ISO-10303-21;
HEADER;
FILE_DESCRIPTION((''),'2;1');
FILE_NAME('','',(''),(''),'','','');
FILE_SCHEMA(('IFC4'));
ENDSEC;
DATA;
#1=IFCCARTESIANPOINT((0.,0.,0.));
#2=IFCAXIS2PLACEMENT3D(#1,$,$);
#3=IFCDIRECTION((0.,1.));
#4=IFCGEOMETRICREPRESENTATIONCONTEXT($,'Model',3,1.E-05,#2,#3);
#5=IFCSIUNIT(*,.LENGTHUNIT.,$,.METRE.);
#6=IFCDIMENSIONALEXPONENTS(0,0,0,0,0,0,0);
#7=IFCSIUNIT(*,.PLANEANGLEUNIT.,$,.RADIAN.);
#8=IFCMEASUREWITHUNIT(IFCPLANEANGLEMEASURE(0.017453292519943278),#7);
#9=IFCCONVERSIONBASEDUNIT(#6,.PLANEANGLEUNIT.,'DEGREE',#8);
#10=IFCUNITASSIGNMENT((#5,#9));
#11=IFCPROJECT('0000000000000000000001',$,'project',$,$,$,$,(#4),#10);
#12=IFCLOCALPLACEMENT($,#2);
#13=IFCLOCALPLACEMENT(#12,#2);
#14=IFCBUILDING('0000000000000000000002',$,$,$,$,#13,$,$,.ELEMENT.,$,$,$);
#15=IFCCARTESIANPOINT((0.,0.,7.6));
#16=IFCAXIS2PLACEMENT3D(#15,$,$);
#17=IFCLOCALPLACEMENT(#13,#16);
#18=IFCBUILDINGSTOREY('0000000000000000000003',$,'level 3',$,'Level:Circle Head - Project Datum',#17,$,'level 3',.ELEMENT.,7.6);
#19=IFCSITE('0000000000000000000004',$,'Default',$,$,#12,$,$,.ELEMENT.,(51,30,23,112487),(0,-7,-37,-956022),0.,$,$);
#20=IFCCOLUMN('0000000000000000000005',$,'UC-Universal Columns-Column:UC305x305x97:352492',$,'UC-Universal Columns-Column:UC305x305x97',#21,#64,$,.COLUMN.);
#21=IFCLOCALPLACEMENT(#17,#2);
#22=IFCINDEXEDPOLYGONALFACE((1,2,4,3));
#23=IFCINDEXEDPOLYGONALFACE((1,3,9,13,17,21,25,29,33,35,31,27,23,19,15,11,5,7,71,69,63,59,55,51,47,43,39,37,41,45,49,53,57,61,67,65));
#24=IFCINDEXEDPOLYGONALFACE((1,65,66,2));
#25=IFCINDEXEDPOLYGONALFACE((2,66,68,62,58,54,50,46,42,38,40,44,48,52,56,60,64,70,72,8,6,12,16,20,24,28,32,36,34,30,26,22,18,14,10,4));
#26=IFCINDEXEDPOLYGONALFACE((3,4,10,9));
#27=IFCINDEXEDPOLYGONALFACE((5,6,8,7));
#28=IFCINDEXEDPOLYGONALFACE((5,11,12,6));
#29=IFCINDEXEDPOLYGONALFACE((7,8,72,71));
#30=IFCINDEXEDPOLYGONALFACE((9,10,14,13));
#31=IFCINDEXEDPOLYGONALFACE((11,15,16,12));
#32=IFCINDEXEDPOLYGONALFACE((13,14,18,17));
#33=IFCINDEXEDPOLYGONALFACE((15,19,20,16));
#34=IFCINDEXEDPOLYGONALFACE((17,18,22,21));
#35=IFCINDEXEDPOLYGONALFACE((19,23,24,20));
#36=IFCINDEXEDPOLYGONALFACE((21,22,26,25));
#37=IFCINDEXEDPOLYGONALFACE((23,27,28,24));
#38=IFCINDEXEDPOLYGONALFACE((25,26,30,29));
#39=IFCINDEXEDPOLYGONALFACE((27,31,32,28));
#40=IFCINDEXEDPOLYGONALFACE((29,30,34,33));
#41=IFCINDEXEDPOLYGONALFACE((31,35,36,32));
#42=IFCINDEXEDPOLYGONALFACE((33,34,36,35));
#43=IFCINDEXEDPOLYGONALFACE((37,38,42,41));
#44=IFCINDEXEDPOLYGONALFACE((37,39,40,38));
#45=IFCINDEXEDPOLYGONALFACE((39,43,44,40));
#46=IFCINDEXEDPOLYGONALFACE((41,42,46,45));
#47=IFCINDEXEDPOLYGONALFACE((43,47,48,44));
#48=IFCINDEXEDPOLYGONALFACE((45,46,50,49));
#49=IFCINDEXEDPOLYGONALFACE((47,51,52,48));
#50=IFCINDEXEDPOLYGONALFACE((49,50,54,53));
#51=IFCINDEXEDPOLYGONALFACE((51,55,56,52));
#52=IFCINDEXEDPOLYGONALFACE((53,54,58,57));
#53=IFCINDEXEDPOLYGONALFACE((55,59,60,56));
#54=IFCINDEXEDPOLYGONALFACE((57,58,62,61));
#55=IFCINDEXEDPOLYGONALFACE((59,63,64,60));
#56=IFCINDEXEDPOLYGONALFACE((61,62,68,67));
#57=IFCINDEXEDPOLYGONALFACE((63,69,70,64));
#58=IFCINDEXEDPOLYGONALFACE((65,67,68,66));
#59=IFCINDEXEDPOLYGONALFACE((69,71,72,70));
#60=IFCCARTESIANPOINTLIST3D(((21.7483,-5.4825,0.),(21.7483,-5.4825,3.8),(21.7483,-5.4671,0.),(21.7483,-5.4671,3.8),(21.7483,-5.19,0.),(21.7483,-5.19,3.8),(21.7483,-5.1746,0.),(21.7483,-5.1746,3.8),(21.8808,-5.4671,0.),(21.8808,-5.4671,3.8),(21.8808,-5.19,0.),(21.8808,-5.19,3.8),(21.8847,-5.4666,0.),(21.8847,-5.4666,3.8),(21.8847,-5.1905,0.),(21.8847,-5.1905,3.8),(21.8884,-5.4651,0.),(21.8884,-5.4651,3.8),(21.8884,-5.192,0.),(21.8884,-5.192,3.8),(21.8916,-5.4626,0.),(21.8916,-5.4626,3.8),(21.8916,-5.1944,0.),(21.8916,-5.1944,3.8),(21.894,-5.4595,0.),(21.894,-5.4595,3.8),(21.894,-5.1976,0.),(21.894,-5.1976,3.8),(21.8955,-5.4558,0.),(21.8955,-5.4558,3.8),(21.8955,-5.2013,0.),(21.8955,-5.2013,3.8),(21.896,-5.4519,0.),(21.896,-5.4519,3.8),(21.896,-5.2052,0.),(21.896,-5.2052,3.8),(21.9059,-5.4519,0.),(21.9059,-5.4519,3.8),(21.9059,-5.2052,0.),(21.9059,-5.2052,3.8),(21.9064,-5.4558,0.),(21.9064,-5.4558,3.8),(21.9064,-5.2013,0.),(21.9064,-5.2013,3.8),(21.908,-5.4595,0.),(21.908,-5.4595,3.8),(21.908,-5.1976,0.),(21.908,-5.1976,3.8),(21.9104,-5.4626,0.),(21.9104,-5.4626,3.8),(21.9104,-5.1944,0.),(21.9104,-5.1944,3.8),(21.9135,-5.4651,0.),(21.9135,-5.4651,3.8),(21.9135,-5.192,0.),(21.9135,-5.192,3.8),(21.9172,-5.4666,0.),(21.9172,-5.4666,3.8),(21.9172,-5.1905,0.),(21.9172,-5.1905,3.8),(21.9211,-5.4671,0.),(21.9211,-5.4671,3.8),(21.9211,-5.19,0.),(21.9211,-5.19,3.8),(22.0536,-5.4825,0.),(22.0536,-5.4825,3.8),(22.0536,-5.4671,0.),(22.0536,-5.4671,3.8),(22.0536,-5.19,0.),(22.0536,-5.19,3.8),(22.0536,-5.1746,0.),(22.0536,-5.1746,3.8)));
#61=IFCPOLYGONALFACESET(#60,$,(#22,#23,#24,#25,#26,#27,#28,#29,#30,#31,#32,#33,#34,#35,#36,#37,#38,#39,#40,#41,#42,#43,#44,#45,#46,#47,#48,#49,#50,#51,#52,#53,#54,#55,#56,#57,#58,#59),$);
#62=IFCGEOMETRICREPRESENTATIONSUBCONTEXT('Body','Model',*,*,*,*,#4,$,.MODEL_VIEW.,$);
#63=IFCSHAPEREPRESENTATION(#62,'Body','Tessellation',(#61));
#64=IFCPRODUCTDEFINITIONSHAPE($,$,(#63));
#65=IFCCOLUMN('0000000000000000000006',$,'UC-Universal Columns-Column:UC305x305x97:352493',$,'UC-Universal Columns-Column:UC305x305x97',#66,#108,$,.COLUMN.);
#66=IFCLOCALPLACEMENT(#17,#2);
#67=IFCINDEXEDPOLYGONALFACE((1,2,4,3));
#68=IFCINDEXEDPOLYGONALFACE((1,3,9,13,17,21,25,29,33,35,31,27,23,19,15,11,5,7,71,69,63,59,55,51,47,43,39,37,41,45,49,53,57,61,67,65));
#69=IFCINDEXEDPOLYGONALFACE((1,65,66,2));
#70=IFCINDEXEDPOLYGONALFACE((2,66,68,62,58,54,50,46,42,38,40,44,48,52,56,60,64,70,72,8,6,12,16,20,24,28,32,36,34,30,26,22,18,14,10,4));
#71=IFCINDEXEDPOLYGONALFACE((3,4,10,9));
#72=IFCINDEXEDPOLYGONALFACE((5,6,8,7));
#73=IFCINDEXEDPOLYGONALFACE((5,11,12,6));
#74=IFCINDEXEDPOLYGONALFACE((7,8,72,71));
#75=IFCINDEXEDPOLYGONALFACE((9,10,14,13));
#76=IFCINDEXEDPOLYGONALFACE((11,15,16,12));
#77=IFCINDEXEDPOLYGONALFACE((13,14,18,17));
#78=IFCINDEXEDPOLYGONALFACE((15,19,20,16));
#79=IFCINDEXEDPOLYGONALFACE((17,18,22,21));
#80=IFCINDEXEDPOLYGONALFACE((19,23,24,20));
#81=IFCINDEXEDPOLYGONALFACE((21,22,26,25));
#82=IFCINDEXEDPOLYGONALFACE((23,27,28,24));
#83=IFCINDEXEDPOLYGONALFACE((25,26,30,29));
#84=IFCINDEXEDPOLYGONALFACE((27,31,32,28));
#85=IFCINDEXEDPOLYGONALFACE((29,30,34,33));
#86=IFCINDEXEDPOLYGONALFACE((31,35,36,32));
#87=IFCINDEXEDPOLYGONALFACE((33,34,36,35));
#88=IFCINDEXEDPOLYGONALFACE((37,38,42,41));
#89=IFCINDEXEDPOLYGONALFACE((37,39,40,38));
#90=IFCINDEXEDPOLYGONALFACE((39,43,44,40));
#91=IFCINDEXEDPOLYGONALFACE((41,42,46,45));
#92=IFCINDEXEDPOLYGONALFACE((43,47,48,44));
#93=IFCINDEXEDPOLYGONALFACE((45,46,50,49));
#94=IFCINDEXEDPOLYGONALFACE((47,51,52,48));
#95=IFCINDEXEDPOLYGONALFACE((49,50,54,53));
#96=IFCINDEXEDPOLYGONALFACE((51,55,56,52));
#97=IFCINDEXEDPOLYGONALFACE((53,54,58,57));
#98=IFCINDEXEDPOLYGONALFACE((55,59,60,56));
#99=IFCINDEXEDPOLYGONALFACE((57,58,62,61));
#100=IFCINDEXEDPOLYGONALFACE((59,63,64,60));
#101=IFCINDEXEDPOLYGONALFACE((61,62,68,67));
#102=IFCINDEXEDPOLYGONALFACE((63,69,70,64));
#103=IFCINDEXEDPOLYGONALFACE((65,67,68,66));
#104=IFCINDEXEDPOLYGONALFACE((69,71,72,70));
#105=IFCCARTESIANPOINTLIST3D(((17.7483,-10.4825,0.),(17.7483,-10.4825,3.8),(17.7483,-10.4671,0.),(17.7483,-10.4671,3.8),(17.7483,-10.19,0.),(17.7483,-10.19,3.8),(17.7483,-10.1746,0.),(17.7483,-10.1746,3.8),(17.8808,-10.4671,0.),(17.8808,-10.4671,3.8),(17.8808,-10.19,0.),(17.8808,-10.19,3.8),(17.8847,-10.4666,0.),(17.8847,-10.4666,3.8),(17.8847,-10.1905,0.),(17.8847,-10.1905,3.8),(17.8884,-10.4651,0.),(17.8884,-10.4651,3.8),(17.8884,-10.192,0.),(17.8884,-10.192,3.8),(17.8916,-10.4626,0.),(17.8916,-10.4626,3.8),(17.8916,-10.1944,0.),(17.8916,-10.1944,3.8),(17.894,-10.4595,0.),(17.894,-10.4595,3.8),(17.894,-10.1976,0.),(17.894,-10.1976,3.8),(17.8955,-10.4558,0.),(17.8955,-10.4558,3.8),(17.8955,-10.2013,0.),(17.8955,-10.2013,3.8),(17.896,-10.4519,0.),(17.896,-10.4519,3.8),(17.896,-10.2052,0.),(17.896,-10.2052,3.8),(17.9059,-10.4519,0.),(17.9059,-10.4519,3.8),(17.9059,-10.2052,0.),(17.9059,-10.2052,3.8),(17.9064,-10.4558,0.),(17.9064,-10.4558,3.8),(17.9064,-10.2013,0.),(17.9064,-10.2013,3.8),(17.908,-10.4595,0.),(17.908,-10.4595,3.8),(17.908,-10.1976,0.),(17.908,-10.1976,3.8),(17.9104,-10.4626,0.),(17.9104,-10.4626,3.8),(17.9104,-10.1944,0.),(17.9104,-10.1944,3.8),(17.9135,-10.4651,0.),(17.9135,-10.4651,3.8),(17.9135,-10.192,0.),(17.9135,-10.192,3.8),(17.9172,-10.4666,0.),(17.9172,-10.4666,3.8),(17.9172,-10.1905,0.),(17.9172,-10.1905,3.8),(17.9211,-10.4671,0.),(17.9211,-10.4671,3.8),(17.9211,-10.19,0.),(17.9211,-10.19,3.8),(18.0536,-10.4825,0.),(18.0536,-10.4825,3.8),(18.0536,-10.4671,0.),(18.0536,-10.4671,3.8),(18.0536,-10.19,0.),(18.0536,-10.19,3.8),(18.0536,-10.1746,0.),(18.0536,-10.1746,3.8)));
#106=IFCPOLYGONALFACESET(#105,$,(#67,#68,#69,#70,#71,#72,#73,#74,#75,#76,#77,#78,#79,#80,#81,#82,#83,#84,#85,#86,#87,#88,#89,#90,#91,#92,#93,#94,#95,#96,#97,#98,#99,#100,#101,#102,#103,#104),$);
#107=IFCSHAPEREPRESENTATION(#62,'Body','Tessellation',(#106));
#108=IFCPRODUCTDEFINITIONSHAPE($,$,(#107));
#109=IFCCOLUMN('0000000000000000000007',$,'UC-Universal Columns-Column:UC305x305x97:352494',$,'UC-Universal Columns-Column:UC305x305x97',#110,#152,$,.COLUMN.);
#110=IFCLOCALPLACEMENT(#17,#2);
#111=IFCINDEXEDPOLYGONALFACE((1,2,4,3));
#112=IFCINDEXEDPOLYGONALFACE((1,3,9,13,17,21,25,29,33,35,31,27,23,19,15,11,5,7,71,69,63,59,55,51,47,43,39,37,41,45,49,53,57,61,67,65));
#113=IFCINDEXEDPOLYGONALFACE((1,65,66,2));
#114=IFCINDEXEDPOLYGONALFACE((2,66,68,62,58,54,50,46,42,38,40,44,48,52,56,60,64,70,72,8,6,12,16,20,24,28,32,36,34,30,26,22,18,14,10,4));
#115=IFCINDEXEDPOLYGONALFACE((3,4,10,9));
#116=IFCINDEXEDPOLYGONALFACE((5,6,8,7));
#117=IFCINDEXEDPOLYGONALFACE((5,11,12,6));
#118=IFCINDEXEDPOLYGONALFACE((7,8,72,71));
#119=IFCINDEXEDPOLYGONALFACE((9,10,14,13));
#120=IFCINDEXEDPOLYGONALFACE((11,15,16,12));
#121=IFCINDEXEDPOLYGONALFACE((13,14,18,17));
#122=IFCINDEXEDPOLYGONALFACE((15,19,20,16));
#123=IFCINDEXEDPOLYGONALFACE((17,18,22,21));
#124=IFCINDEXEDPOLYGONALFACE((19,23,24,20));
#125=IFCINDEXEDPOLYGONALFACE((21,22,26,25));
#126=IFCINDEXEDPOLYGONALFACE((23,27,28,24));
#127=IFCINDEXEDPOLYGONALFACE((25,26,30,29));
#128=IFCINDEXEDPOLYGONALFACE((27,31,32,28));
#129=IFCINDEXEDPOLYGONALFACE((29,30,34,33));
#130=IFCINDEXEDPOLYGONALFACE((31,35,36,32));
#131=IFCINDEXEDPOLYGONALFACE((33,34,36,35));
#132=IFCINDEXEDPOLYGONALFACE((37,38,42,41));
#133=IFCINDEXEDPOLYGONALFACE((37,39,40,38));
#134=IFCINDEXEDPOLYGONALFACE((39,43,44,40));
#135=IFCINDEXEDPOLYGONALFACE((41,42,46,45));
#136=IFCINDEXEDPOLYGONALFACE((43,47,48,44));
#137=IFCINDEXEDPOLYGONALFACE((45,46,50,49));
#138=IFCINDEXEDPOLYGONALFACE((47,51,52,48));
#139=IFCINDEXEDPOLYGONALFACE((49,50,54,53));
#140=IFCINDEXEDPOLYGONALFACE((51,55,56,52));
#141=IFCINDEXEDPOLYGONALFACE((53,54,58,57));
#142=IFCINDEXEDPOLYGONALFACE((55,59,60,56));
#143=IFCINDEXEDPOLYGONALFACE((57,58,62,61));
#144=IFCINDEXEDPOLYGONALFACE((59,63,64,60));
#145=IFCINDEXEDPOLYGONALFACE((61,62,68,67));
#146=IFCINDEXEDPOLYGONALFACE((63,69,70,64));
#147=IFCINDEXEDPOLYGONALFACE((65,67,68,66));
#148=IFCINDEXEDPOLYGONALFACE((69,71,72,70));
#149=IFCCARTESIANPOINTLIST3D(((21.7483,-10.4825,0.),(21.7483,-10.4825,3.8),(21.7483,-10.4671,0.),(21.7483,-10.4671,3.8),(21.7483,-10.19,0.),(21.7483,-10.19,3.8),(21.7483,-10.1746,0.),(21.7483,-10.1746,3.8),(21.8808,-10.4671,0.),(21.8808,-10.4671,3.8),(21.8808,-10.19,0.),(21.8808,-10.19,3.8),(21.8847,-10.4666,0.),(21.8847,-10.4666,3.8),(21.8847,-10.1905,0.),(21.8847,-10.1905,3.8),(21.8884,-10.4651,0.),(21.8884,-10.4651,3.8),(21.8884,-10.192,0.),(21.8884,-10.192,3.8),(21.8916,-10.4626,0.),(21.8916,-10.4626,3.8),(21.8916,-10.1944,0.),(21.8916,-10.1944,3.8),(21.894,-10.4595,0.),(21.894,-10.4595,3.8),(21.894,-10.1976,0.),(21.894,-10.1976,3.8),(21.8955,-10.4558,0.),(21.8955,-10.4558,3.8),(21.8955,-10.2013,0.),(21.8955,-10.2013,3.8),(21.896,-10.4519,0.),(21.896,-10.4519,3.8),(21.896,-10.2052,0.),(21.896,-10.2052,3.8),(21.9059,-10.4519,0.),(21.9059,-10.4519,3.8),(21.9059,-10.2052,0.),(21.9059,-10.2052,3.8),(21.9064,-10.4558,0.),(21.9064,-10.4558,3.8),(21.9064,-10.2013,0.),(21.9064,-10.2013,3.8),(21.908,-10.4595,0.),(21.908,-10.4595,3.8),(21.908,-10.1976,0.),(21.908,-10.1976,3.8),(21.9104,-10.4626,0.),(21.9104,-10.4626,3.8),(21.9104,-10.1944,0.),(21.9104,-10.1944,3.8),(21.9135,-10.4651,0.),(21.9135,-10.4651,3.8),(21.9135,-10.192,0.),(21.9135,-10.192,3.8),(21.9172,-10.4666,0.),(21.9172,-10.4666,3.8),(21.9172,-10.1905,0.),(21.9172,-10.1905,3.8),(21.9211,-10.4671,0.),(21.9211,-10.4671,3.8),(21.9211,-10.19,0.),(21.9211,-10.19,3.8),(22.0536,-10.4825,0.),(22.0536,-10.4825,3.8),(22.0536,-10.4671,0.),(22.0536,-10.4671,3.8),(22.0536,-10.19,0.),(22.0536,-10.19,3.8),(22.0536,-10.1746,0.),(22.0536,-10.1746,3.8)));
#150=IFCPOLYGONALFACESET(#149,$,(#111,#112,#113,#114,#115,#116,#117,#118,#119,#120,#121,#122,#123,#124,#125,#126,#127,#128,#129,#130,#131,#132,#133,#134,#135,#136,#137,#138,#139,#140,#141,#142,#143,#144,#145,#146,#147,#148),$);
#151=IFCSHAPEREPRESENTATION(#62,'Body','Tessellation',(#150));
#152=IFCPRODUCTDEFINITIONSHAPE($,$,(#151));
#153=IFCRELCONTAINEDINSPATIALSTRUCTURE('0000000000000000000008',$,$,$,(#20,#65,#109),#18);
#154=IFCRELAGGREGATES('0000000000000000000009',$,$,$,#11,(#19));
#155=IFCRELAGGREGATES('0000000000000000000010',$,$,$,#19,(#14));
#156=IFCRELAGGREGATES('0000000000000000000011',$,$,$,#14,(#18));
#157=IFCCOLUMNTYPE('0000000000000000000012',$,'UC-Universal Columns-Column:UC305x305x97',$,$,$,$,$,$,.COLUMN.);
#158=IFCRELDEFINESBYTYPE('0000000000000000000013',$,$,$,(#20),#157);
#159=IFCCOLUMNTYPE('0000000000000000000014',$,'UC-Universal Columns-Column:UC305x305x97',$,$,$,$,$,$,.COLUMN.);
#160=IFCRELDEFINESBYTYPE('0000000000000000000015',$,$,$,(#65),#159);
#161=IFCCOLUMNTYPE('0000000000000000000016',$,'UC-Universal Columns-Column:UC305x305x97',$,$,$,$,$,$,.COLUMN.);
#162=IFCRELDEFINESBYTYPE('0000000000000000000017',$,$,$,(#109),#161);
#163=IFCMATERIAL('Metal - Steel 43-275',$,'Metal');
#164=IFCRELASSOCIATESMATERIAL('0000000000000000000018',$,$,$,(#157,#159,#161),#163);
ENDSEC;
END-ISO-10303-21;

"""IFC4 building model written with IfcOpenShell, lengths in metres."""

from ifc_helpers import new_model, entity, si_unit, converted_unit, direction, frame, frame_2d, origin, place, context, subcontext, project, spatial, i_section, extrude, source, transform, mapped, material, material_profile, profile_set, type_object, type_shapes, element, save


model = new_model("IFC4")

# Units and contexts
model_context = context("Model", 3, precision=1e-05, world=origin(), true_north=direction((0.0, 1.0)))
body_context = subcontext(model_context, "Body", "Model", "MODEL_VIEW")
ifc_project = project(units=[si_unit("LENGTHUNIT", "METRE"), converted_unit("PLANEANGLEUNIT", "DEGREE", entity("IfcPlaneAngleMeasure", 0.017453292519943278), si_unit("PLANEANGLEUNIT", "RADIAN"), dimensions=[0, 0, 0, 0, 0, 0, 0])], contexts=[model_context])

# Site, building, storey
site_placement = place(None, origin())
site = spatial("IfcSite", under=ifc_project, at=site_placement, Name="Default", CompositionType="ELEMENT", RefLatitude=(51, 30, 23, 112487), RefLongitude=(0, -7, -37, -956022), RefElevation=0.0)
building_placement = place(site_placement, origin())
building = spatial("IfcBuilding", under=site, at=building_placement, CompositionType="ELEMENT")
storey_placement = place(building_placement, frame((0.0, 0.0, 7.6)))
storey = spatial("IfcBuildingStorey", under=building, at=storey_placement, Name="level 3", ObjectType="Level:Circle Head - Project Datum", LongName="level 3", CompositionType="ELEMENT", Elevation=7.6)

# Columns
ifc_material_1 = material(Name="Metal - Steel 43-275", Category="Metal")
ifc_material_profile_1 = material_profile(ifc_material_1, i_section(OverallWidth=0.3053, OverallDepth=0.3079, WebThickness=0.0099, FlangeThickness=0.0154, FilletRadius=0.0152, at=frame_2d((0.0, 0.0), x_axis=(1.0, 0.0))), Name="UC305x305x97")
ifc_profile_set_1 = profile_set([ifc_material_profile_1], Name="UC305x305x97")
column_type_1 = type_object("IfcColumnType", Name="UC-Universal Columns-Column:UC305x305x97", PredefinedType="COLUMN", material=ifc_profile_set_1)
shared_shape_1 = source(origin(), body_context, "Body", "SweptSolid", [
    extrude(i_section(OverallWidth=0.3053, OverallDepth=0.3079, WebThickness=0.0099, FlangeThickness=0.0154, FilletRadius=0.0152, at=frame_2d((0.0, 0.0), x_axis=(1.0, 0.0))), frame((21.901, -5.3285, 7.6), z_axis=(0.0, 0.0, 1.0), x_axis=(-1.0, 0.0, 0.0)), (0.0, 0.0, 1.0), 3.8),
])
type_shapes(column_type_1, [shared_shape_1])
column_1_placement = place(storey_placement, frame((0.0, 0.0, -7.6)))
element("IfcColumn", 1, at=column_1_placement, inside=storey, type_object=column_type_1, Name="UC-Universal Columns-Column:UC305x305x97:352492", ObjectType="UC-Universal Columns-Column:UC305x305x97", PredefinedType="COLUMN", context=body_context, shape_type="MappedRepresentation", body=[
    mapped(shared_shape_1, transform((0.0, 0.0, 0.0), scale=1.0)),
])
column_type_2 = type_object("IfcColumnType", Name="UC-Universal Columns-Column:UC305x305x97", PredefinedType="COLUMN", material=ifc_profile_set_1)
shared_shape_2 = source(origin(), body_context, "Body", "SweptSolid", [
    extrude(i_section(OverallWidth=0.3053, OverallDepth=0.3079, WebThickness=0.0099, FlangeThickness=0.0154, FilletRadius=0.0152, at=frame_2d((0.0, 0.0), x_axis=(1.0, 0.0))), frame((17.901, -10.3285, 7.6), z_axis=(0.0, 0.0, 1.0), x_axis=(-1.0, 0.0, 0.0)), (0.0, 0.0, 1.0), 3.8),
])
type_shapes(column_type_2, [shared_shape_2])
column_2_placement = place(storey_placement, frame((0.0, 0.0, -7.6)))
element("IfcColumn", 2, at=column_2_placement, inside=storey, type_object=column_type_2, Name="UC-Universal Columns-Column:UC305x305x97:352493", ObjectType="UC-Universal Columns-Column:UC305x305x97", PredefinedType="COLUMN", context=body_context, shape_type="MappedRepresentation", body=[
    mapped(shared_shape_2, transform((0.0, 0.0, 0.0), scale=1.0)),
])
column_type_3 = type_object("IfcColumnType", Name="UC-Universal Columns-Column:UC305x305x97", PredefinedType="COLUMN", material=ifc_profile_set_1)
shared_shape_3 = source(origin(), body_context, "Body", "SweptSolid", [
    extrude(i_section(OverallWidth=0.3053, OverallDepth=0.3079, WebThickness=0.0099, FlangeThickness=0.0154, FilletRadius=0.0152, at=frame_2d((0.0, 0.0), x_axis=(1.0, 0.0))), frame((21.901, -10.3285, 7.6), z_axis=(0.0, 0.0, 1.0), x_axis=(-1.0, 0.0, 0.0)), (0.0, 0.0, 1.0), 3.8),
])
type_shapes(column_type_3, [shared_shape_3])
column_3_placement = place(storey_placement, frame((0.0, 0.0, -7.6)))
element("IfcColumn", 3, at=column_3_placement, inside=storey, type_object=column_type_3, Name="UC-Universal Columns-Column:UC305x305x97:352494", ObjectType="UC-Universal Columns-Column:UC305x305x97", PredefinedType="COLUMN", context=body_context, shape_type="MappedRepresentation", body=[
    mapped(shared_shape_3, transform((0.0, 0.0, 0.0), scale=1.0)),
])

save(model, "model.ifc")
